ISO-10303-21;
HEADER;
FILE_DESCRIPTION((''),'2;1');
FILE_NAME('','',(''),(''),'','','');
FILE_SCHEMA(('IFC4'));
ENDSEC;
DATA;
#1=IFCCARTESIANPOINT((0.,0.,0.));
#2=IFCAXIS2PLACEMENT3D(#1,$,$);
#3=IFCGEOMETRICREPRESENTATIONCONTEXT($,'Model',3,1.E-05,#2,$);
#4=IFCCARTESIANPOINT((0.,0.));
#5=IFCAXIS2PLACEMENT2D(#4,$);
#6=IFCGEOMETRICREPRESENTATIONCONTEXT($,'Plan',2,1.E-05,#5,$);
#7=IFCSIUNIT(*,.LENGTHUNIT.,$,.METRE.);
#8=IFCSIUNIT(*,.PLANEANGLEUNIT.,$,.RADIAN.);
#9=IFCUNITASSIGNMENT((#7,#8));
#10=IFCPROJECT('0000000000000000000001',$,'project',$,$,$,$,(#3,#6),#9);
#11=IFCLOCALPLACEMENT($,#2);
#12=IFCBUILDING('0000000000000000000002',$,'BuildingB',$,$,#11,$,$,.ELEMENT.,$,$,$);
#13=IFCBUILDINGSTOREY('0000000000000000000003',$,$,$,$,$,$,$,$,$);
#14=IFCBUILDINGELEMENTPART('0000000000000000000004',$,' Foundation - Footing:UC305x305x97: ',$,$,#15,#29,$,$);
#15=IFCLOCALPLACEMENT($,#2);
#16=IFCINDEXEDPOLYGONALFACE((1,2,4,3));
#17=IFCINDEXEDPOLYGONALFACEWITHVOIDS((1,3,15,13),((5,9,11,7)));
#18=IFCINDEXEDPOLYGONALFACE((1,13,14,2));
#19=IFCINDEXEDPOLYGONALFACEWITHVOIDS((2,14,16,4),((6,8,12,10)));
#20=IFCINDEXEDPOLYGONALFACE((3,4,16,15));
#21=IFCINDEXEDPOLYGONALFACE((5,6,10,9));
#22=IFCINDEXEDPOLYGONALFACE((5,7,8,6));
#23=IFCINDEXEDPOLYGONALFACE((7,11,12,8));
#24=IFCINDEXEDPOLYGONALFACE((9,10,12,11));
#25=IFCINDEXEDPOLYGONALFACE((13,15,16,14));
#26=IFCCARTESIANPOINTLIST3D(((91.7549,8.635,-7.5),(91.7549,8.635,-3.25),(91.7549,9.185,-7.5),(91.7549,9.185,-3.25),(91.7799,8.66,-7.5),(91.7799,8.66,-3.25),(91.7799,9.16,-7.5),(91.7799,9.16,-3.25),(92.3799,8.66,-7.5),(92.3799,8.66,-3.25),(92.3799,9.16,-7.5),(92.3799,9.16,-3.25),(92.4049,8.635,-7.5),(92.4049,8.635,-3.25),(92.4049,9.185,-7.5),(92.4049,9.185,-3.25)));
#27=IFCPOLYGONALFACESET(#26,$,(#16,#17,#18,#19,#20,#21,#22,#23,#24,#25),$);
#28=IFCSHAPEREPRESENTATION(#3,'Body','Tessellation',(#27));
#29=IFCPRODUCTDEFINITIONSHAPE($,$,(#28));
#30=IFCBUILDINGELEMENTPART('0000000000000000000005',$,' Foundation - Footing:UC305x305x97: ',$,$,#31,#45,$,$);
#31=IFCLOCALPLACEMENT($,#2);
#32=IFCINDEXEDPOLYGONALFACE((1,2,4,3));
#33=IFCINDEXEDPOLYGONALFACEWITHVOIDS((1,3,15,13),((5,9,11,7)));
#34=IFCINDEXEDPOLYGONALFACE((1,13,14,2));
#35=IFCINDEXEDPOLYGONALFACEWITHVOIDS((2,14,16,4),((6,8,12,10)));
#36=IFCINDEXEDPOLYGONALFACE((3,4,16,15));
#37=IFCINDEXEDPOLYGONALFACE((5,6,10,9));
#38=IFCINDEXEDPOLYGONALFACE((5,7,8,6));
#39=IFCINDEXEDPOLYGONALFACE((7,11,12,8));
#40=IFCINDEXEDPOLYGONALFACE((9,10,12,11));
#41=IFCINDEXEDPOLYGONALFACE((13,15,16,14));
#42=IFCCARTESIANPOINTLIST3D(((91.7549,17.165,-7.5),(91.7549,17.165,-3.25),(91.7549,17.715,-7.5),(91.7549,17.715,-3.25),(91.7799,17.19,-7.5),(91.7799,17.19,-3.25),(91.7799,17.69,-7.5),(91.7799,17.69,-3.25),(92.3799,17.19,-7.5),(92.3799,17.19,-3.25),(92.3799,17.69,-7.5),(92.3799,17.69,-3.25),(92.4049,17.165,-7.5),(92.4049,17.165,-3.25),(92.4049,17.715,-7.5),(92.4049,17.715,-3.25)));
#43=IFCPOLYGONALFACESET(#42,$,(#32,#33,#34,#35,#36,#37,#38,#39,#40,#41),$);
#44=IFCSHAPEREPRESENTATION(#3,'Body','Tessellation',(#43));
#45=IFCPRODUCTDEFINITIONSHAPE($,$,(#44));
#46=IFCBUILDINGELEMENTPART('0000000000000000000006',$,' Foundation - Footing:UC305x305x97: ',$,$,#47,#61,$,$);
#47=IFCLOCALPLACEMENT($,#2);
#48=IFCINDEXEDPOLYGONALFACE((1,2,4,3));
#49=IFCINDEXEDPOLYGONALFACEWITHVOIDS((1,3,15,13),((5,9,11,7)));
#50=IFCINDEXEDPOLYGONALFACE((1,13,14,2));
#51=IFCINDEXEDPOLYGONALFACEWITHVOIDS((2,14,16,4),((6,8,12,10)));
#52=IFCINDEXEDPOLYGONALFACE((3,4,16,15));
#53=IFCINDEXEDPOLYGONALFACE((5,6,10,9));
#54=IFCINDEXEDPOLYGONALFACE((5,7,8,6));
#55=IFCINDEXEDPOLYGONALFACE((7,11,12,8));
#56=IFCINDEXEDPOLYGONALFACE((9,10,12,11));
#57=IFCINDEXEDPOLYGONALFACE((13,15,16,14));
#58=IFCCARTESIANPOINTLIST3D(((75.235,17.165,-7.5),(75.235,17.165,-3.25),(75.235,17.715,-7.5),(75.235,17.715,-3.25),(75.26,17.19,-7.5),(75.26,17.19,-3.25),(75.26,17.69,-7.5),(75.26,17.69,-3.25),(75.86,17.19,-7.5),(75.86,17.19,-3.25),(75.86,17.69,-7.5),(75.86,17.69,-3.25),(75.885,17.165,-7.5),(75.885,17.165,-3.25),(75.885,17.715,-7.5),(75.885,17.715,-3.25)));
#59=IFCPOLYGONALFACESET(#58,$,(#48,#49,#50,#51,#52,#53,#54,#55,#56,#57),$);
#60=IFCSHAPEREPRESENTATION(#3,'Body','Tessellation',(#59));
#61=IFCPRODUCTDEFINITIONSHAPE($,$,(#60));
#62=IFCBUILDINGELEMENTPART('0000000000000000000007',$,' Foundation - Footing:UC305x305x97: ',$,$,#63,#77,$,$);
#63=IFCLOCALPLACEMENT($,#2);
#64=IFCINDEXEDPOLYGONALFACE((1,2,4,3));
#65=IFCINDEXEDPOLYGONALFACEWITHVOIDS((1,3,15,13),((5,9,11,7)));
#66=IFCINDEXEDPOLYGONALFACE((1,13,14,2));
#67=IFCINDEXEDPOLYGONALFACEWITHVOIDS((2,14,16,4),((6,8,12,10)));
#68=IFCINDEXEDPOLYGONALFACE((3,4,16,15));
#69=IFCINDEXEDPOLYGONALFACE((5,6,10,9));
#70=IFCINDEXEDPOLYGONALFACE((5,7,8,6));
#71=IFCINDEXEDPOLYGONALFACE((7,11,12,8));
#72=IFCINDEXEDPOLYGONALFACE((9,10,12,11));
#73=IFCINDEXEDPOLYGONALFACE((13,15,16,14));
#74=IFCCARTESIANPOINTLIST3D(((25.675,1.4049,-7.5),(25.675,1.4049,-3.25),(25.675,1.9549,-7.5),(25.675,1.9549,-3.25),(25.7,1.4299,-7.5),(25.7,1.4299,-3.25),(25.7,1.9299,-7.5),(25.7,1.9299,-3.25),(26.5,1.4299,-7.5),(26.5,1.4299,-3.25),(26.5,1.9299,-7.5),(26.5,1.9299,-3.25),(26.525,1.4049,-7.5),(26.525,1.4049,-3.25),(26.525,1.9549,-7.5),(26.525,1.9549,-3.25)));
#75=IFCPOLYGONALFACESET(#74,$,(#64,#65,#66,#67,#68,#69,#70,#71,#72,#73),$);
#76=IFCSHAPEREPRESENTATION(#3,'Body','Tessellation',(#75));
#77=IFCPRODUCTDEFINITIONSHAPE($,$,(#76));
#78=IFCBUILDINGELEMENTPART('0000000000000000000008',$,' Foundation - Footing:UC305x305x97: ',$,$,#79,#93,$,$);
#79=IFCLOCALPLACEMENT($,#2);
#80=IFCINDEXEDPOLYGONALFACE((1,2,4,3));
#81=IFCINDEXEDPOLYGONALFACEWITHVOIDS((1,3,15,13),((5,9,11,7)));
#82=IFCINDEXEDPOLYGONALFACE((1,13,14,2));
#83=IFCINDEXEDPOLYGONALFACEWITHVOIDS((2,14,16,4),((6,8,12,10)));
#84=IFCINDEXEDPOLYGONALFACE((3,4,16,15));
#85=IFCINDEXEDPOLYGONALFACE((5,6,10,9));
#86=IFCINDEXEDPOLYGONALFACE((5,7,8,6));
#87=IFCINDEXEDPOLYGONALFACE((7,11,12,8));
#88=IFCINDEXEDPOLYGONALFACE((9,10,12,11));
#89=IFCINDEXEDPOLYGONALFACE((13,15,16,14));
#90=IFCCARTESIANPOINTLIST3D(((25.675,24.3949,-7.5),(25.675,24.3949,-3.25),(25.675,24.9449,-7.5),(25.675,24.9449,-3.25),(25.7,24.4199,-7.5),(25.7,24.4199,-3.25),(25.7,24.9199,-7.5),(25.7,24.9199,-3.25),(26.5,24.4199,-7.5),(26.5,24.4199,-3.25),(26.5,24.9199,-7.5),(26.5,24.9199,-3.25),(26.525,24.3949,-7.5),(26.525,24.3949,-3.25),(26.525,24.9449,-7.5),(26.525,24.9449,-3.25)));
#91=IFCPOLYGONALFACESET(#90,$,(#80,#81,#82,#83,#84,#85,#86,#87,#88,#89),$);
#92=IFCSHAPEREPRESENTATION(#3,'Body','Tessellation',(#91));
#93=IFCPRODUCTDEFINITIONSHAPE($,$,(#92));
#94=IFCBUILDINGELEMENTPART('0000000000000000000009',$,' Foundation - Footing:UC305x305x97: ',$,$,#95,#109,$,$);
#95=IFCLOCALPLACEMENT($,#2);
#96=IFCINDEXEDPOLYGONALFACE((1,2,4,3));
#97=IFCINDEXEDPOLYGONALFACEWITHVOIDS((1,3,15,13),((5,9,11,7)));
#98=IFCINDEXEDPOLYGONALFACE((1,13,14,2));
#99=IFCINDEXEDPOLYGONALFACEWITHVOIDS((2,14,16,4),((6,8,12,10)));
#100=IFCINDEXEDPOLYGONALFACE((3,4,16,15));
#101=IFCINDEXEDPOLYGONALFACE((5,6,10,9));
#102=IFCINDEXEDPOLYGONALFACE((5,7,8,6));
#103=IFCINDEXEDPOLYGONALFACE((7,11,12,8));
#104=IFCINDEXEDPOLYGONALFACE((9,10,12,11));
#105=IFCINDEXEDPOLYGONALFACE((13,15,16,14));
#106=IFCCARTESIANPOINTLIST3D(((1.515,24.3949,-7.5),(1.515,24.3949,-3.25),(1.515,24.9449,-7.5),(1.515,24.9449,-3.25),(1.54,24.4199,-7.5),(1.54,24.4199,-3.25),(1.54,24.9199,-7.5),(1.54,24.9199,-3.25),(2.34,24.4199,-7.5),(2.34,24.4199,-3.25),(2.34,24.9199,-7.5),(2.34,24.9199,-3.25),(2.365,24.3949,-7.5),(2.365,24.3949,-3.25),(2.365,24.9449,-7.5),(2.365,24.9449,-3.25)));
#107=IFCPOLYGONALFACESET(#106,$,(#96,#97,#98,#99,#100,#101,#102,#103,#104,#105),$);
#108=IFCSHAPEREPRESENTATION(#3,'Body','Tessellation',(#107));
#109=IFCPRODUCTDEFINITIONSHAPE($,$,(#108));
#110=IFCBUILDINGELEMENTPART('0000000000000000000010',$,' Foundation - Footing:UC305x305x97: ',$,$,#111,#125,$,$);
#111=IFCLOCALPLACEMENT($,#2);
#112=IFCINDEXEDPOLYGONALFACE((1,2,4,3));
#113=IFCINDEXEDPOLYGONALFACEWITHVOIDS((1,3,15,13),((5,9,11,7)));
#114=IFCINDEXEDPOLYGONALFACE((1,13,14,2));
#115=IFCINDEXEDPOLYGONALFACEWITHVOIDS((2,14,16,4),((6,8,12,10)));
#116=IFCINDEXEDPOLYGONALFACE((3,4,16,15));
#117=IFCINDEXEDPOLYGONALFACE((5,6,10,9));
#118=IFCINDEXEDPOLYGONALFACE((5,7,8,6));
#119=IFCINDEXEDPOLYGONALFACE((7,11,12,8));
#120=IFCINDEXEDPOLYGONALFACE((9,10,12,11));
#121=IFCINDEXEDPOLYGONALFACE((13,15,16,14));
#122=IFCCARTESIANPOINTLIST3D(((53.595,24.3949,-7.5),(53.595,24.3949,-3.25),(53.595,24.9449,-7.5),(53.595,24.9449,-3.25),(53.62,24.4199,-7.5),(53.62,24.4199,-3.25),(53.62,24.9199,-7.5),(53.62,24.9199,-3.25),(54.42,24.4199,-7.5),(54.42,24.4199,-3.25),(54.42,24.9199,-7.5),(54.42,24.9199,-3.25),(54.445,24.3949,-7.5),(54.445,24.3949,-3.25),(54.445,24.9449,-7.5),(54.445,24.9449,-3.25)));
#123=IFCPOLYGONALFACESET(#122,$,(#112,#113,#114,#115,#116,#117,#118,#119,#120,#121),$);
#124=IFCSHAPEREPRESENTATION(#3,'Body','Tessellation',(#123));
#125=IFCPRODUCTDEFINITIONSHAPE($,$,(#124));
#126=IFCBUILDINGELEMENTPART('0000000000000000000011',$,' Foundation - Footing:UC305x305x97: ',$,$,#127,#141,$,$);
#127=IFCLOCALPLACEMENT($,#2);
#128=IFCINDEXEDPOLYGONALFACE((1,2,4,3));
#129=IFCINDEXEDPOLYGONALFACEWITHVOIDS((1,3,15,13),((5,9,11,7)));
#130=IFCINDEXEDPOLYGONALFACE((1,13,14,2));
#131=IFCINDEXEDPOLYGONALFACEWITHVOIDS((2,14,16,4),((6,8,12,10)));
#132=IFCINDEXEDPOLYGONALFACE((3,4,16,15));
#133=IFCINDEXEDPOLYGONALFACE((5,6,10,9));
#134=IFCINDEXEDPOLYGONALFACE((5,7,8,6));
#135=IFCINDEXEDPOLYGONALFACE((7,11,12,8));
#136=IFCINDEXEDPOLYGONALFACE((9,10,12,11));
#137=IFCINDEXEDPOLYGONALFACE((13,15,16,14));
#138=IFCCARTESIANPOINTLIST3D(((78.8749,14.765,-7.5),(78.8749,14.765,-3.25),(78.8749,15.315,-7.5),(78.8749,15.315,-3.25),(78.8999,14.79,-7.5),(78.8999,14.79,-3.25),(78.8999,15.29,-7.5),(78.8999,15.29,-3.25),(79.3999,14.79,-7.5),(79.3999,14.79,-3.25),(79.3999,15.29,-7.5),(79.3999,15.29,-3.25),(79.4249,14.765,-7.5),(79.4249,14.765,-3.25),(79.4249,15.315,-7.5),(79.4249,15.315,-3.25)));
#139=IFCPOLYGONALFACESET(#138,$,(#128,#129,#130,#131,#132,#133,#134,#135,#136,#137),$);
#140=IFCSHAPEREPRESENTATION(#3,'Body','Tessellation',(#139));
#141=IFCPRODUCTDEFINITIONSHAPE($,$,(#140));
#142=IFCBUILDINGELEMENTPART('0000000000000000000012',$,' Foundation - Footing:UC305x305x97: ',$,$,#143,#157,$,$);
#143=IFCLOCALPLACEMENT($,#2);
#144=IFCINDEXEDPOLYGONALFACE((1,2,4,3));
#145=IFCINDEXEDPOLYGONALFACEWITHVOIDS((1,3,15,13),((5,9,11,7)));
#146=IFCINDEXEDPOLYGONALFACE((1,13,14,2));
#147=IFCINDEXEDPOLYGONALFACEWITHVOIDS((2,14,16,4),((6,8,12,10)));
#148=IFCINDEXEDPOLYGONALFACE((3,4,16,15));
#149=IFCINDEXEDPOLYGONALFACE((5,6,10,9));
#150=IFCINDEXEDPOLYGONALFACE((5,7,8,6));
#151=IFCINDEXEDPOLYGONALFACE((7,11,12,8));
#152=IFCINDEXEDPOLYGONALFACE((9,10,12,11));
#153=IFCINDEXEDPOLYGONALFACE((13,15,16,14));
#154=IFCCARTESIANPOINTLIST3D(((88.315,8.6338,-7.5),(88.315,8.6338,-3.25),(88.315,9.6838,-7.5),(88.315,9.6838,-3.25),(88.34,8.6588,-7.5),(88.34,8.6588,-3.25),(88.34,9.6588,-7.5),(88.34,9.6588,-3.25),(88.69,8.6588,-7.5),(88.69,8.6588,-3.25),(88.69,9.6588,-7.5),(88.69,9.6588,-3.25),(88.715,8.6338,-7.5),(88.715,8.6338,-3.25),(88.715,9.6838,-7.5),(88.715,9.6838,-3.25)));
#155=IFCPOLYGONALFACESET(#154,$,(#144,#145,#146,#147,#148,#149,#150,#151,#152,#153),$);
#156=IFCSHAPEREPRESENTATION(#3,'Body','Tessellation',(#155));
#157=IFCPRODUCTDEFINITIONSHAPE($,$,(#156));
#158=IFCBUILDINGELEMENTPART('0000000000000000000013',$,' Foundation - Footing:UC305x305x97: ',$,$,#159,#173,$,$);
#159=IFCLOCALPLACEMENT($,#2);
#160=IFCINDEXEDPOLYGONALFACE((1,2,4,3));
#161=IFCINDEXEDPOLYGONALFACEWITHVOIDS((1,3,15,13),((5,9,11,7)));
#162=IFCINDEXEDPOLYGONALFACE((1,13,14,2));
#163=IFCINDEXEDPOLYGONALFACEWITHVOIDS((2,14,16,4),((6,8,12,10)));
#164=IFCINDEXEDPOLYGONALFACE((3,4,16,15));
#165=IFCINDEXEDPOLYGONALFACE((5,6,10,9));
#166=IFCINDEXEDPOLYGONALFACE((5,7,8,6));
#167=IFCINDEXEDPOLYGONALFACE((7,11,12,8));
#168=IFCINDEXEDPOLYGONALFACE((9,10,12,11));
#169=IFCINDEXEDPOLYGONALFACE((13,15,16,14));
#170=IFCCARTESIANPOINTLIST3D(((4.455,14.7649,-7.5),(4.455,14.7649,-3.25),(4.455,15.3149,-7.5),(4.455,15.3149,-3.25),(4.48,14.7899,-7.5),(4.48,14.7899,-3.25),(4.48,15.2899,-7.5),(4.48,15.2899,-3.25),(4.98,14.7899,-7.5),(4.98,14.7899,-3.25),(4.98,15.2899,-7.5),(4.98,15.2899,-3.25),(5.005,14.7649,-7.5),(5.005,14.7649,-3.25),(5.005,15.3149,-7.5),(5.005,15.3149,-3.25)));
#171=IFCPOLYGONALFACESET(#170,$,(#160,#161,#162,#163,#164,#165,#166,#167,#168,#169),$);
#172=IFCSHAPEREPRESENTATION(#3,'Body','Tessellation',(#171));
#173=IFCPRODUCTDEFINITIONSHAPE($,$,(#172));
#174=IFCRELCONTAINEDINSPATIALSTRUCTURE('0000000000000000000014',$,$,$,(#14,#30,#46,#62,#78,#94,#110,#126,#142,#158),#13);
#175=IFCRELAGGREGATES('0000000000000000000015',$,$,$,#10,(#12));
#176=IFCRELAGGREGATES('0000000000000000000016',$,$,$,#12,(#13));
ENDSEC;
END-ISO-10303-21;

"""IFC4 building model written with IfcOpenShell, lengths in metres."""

from ifc_helpers import new_model, si_unit, origin, origin_2d, place, context, project, spatial, polyline, outline, extrude, element, save


model = new_model("IFC4")

# Units and contexts
model_context = context("Model", 3, precision=1e-05, world=origin())
plan_context = context("Plan", 2, precision=1e-05, world=origin_2d())
ifc_project = project(units=[si_unit("LENGTHUNIT", "METRE"), si_unit("PLANEANGLEUNIT", "RADIAN")], contexts=[model_context, plan_context])

# Building, storey
building_placement = place(None, origin())
building = spatial("IfcBuilding", under=ifc_project, at=building_placement, Name="BuildingB", CompositionType="ELEMENT")
storey = spatial("IfcBuildingStorey", under=building)

# Building element parts, openings
building_element_part_1 = element("IfcBuildingElementPart", 1, inside=storey, Name=" Foundation - Footing:UC305x305x97: ", context=model_context, shape_type="SweptSolid", body=[
    extrude(outline(polyline([(92.4049, 8.635, -7.5), (91.7549, 8.635, -7.5), (91.7549, 9.185, -7.5), (92.4049, 9.185, -7.5), (92.4049, 8.635, -7.5)])), None, (0.0, 0.0, 1.0), 4.25),
])
element("IfcOpeningElement", 2, inside=storey, cuts=building_element_part_1, context=model_context, shape_type="SweptSolid", body=[
    extrude(outline(polyline([(92.3799, 8.66, -7.5), (91.7799, 8.66, -7.5), (91.7799, 9.16, -7.5), (92.3799, 9.16, -7.5), (92.3799, 8.66, -7.5)])), None, (0.0, 0.0, 1.0), 4.25),
])
building_element_part_2 = element("IfcBuildingElementPart", 3, inside=storey, Name=" Foundation - Footing:UC305x305x97: ", context=model_context, shape_type="SweptSolid", body=[
    extrude(outline(polyline([(92.4049, 17.715, -7.5), (91.7549, 17.715, -7.5), (91.7549, 17.165, -7.5), (92.4049, 17.165, -7.5), (92.4049, 17.715, -7.5)])), None, (0.0, 0.0, 1.0), 4.25),
])
element("IfcOpeningElement", 4, inside=storey, cuts=building_element_part_2, context=model_context, shape_type="SweptSolid", body=[
    extrude(outline(polyline([(92.3799, 17.69, -7.5), (91.7799, 17.69, -7.5), (91.7799, 17.19, -7.5), (92.3799, 17.19, -7.5), (92.3799, 17.69, -7.5)])), None, (0.0, 0.0, 1.0), 4.25),
])
building_element_part_3 = element("IfcBuildingElementPart", 5, inside=storey, Name=" Foundation - Footing:UC305x305x97: ", context=model_context, shape_type="SweptSolid", body=[
    extrude(outline(polyline([(75.235, 17.715, -7.5), (75.885, 17.715, -7.5), (75.885, 17.165, -7.5), (75.235, 17.165, -7.5), (75.235, 17.715, -7.5)])), None, (0.0, 0.0, 1.0), 4.25),
])
element("IfcOpeningElement", 6, inside=storey, cuts=building_element_part_3, context=model_context, shape_type="SweptSolid", body=[
    extrude(outline(polyline([(75.26, 17.69, -7.5), (75.86, 17.69, -7.5), (75.86, 17.19, -7.5), (75.26, 17.19, -7.5), (75.26, 17.69, -7.5)])), None, (0.0, 0.0, 1.0), 4.25),
])
building_element_part_4 = element("IfcBuildingElementPart", 7, inside=storey, Name=" Foundation - Footing:UC305x305x97: ", context=model_context, shape_type="SweptSolid", body=[
    extrude(outline(polyline([(25.675, 1.4049, -7.5), (26.525, 1.4049, -7.5), (26.525, 1.9549, -7.5), (25.675, 1.9549, -7.5), (25.675, 1.4049, -7.5)])), None, (0.0, 0.0, 1.0), 4.25),
])
element("IfcOpeningElement", 8, inside=storey, cuts=building_element_part_4, context=model_context, shape_type="SweptSolid", body=[
    extrude(outline(polyline([(25.7, 1.4299, -7.5), (26.5, 1.4299, -7.5), (26.5, 1.9299, -7.5), (25.7, 1.9299, -7.5), (25.7, 1.4299, -7.5)])), None, (0.0, 0.0, 1.0), 4.25),
])
building_element_part_5 = element("IfcBuildingElementPart", 9, inside=storey, Name=" Foundation - Footing:UC305x305x97: ", context=model_context, shape_type="SweptSolid", body=[
    extrude(outline(polyline([(25.675, 24.3949, -7.5), (26.525, 24.3949, -7.5), (26.525, 24.9449, -7.5), (25.675, 24.9449, -7.5), (25.675, 24.3949, -7.5)])), None, (0.0, 0.0, 1.0), 4.25),
])
element("IfcOpeningElement", 10, inside=storey, cuts=building_element_part_5, context=model_context, shape_type="SweptSolid", body=[
    extrude(outline(polyline([(25.7, 24.4199, -7.5), (26.5, 24.4199, -7.5), (26.5, 24.9199, -7.5), (25.7, 24.9199, -7.5), (25.7, 24.4199, -7.5)])), None, (0.0, 0.0, 1.0), 4.25),
])
building_element_part_6 = element("IfcBuildingElementPart", 11, inside=storey, Name=" Foundation - Footing:UC305x305x97: ", context=model_context, shape_type="SweptSolid", body=[
    extrude(outline(polyline([(1.515, 24.3949, -7.5), (2.365, 24.3949, -7.5), (2.365, 24.9449, -7.5), (1.515, 24.9449, -7.5), (1.515, 24.3949, -7.5)])), None, (0.0, 0.0, 1.0), 4.25),
])
element("IfcOpeningElement", 12, inside=storey, cuts=building_element_part_6, context=model_context, shape_type="SweptSolid", body=[
    extrude(outline(polyline([(1.54, 24.4199, -7.5), (2.34, 24.4199, -7.5), (2.34, 24.9199, -7.5), (1.54, 24.9199, -7.5), (1.54, 24.4199, -7.5)])), None, (0.0, 0.0, 1.0), 4.25),
])
building_element_part_7 = element("IfcBuildingElementPart", 13, inside=storey, Name=" Foundation - Footing:UC305x305x97: ", context=model_context, shape_type="SweptSolid", body=[
    extrude(outline(polyline([(54.445, 24.3949, -7.5), (53.595, 24.3949, -7.5), (53.595, 24.9449, -7.5), (54.445, 24.9449, -7.5), (54.445, 24.3949, -7.5)])), None, (0.0, 0.0, 1.0), 4.25),
])
element("IfcOpeningElement", 14, inside=storey, cuts=building_element_part_7, context=model_context, shape_type="SweptSolid", body=[
    extrude(outline(polyline([(54.42, 24.4199, -7.5), (53.62, 24.4199, -7.5), (53.62, 24.9199, -7.5), (54.42, 24.9199, -7.5), (54.42, 24.4199, -7.5)])), None, (0.0, 0.0, 1.0), 4.25),
])
building_element_part_8 = element("IfcBuildingElementPart", 15, inside=storey, Name=" Foundation - Footing:UC305x305x97: ", context=model_context, shape_type="SweptSolid", body=[
    extrude(outline(polyline([(78.8749, 15.315, -7.5), (79.4249, 15.315, -7.5), (79.4249, 14.765, -7.5), (78.8749, 14.765, -7.5), (78.8749, 15.315, -7.5)])), None, (0.0, 0.0, 1.0), 4.25),
])
element("IfcOpeningElement", 16, inside=storey, cuts=building_element_part_8, context=model_context, shape_type="SweptSolid", body=[
    extrude(outline(polyline([(78.8999, 15.29, -7.5), (79.3999, 15.29, -7.5), (79.3999, 14.79, -7.5), (78.8999, 14.79, -7.5), (78.8999, 15.29, -7.5)])), None, (0.0, 0.0, 1.0), 4.25),
])
building_element_part_9 = element("IfcBuildingElementPart", 17, inside=storey, Name=" Foundation - Footing:UC305x305x97: ", context=model_context, shape_type="SweptSolid", body=[
    extrude(outline(polyline([(88.315, 8.6338, -7.5), (88.715, 8.6338, -7.5), (88.715, 9.6838, -7.5), (88.315, 9.6838, -7.5), (88.315, 8.6338, -7.5)])), None, (0.0, 0.0, 1.0), 4.25),
])
element("IfcOpeningElement", 18, inside=storey, cuts=building_element_part_9, context=model_context, shape_type="SweptSolid", body=[
    extrude(outline(polyline([(88.34, 8.6588, -7.5), (88.69, 8.6588, -7.5), (88.69, 9.6588, -7.5), (88.34, 9.6588, -7.5), (88.34, 8.6588, -7.5)])), None, (0.0, 0.0, 1.0), 4.25),
])
building_element_part_10 = element("IfcBuildingElementPart", 19, inside=storey, Name=" Foundation - Footing:UC305x305x97: ", context=model_context, shape_type="SweptSolid", body=[
    extrude(outline(polyline([(5.005, 15.3149, -7.5), (4.455, 15.3149, -7.5), (4.455, 14.7649, -7.5), (5.005, 14.7649, -7.5), (5.005, 15.3149, -7.5)])), None, (0.0, 0.0, 1.0), 4.25),
])
element("IfcOpeningElement", 20, inside=storey, cuts=building_element_part_10, context=model_context, shape_type="SweptSolid", body=[
    extrude(outline(polyline([(4.98, 15.2899, -7.5), (4.48, 15.2899, -7.5), (4.48, 14.7899, -7.5), (4.98, 14.7899, -7.5), (4.98, 15.2899, -7.5)])), None, (0.0, 0.0, 1.0), 4.25),
])

save(model, "model.ifc")
